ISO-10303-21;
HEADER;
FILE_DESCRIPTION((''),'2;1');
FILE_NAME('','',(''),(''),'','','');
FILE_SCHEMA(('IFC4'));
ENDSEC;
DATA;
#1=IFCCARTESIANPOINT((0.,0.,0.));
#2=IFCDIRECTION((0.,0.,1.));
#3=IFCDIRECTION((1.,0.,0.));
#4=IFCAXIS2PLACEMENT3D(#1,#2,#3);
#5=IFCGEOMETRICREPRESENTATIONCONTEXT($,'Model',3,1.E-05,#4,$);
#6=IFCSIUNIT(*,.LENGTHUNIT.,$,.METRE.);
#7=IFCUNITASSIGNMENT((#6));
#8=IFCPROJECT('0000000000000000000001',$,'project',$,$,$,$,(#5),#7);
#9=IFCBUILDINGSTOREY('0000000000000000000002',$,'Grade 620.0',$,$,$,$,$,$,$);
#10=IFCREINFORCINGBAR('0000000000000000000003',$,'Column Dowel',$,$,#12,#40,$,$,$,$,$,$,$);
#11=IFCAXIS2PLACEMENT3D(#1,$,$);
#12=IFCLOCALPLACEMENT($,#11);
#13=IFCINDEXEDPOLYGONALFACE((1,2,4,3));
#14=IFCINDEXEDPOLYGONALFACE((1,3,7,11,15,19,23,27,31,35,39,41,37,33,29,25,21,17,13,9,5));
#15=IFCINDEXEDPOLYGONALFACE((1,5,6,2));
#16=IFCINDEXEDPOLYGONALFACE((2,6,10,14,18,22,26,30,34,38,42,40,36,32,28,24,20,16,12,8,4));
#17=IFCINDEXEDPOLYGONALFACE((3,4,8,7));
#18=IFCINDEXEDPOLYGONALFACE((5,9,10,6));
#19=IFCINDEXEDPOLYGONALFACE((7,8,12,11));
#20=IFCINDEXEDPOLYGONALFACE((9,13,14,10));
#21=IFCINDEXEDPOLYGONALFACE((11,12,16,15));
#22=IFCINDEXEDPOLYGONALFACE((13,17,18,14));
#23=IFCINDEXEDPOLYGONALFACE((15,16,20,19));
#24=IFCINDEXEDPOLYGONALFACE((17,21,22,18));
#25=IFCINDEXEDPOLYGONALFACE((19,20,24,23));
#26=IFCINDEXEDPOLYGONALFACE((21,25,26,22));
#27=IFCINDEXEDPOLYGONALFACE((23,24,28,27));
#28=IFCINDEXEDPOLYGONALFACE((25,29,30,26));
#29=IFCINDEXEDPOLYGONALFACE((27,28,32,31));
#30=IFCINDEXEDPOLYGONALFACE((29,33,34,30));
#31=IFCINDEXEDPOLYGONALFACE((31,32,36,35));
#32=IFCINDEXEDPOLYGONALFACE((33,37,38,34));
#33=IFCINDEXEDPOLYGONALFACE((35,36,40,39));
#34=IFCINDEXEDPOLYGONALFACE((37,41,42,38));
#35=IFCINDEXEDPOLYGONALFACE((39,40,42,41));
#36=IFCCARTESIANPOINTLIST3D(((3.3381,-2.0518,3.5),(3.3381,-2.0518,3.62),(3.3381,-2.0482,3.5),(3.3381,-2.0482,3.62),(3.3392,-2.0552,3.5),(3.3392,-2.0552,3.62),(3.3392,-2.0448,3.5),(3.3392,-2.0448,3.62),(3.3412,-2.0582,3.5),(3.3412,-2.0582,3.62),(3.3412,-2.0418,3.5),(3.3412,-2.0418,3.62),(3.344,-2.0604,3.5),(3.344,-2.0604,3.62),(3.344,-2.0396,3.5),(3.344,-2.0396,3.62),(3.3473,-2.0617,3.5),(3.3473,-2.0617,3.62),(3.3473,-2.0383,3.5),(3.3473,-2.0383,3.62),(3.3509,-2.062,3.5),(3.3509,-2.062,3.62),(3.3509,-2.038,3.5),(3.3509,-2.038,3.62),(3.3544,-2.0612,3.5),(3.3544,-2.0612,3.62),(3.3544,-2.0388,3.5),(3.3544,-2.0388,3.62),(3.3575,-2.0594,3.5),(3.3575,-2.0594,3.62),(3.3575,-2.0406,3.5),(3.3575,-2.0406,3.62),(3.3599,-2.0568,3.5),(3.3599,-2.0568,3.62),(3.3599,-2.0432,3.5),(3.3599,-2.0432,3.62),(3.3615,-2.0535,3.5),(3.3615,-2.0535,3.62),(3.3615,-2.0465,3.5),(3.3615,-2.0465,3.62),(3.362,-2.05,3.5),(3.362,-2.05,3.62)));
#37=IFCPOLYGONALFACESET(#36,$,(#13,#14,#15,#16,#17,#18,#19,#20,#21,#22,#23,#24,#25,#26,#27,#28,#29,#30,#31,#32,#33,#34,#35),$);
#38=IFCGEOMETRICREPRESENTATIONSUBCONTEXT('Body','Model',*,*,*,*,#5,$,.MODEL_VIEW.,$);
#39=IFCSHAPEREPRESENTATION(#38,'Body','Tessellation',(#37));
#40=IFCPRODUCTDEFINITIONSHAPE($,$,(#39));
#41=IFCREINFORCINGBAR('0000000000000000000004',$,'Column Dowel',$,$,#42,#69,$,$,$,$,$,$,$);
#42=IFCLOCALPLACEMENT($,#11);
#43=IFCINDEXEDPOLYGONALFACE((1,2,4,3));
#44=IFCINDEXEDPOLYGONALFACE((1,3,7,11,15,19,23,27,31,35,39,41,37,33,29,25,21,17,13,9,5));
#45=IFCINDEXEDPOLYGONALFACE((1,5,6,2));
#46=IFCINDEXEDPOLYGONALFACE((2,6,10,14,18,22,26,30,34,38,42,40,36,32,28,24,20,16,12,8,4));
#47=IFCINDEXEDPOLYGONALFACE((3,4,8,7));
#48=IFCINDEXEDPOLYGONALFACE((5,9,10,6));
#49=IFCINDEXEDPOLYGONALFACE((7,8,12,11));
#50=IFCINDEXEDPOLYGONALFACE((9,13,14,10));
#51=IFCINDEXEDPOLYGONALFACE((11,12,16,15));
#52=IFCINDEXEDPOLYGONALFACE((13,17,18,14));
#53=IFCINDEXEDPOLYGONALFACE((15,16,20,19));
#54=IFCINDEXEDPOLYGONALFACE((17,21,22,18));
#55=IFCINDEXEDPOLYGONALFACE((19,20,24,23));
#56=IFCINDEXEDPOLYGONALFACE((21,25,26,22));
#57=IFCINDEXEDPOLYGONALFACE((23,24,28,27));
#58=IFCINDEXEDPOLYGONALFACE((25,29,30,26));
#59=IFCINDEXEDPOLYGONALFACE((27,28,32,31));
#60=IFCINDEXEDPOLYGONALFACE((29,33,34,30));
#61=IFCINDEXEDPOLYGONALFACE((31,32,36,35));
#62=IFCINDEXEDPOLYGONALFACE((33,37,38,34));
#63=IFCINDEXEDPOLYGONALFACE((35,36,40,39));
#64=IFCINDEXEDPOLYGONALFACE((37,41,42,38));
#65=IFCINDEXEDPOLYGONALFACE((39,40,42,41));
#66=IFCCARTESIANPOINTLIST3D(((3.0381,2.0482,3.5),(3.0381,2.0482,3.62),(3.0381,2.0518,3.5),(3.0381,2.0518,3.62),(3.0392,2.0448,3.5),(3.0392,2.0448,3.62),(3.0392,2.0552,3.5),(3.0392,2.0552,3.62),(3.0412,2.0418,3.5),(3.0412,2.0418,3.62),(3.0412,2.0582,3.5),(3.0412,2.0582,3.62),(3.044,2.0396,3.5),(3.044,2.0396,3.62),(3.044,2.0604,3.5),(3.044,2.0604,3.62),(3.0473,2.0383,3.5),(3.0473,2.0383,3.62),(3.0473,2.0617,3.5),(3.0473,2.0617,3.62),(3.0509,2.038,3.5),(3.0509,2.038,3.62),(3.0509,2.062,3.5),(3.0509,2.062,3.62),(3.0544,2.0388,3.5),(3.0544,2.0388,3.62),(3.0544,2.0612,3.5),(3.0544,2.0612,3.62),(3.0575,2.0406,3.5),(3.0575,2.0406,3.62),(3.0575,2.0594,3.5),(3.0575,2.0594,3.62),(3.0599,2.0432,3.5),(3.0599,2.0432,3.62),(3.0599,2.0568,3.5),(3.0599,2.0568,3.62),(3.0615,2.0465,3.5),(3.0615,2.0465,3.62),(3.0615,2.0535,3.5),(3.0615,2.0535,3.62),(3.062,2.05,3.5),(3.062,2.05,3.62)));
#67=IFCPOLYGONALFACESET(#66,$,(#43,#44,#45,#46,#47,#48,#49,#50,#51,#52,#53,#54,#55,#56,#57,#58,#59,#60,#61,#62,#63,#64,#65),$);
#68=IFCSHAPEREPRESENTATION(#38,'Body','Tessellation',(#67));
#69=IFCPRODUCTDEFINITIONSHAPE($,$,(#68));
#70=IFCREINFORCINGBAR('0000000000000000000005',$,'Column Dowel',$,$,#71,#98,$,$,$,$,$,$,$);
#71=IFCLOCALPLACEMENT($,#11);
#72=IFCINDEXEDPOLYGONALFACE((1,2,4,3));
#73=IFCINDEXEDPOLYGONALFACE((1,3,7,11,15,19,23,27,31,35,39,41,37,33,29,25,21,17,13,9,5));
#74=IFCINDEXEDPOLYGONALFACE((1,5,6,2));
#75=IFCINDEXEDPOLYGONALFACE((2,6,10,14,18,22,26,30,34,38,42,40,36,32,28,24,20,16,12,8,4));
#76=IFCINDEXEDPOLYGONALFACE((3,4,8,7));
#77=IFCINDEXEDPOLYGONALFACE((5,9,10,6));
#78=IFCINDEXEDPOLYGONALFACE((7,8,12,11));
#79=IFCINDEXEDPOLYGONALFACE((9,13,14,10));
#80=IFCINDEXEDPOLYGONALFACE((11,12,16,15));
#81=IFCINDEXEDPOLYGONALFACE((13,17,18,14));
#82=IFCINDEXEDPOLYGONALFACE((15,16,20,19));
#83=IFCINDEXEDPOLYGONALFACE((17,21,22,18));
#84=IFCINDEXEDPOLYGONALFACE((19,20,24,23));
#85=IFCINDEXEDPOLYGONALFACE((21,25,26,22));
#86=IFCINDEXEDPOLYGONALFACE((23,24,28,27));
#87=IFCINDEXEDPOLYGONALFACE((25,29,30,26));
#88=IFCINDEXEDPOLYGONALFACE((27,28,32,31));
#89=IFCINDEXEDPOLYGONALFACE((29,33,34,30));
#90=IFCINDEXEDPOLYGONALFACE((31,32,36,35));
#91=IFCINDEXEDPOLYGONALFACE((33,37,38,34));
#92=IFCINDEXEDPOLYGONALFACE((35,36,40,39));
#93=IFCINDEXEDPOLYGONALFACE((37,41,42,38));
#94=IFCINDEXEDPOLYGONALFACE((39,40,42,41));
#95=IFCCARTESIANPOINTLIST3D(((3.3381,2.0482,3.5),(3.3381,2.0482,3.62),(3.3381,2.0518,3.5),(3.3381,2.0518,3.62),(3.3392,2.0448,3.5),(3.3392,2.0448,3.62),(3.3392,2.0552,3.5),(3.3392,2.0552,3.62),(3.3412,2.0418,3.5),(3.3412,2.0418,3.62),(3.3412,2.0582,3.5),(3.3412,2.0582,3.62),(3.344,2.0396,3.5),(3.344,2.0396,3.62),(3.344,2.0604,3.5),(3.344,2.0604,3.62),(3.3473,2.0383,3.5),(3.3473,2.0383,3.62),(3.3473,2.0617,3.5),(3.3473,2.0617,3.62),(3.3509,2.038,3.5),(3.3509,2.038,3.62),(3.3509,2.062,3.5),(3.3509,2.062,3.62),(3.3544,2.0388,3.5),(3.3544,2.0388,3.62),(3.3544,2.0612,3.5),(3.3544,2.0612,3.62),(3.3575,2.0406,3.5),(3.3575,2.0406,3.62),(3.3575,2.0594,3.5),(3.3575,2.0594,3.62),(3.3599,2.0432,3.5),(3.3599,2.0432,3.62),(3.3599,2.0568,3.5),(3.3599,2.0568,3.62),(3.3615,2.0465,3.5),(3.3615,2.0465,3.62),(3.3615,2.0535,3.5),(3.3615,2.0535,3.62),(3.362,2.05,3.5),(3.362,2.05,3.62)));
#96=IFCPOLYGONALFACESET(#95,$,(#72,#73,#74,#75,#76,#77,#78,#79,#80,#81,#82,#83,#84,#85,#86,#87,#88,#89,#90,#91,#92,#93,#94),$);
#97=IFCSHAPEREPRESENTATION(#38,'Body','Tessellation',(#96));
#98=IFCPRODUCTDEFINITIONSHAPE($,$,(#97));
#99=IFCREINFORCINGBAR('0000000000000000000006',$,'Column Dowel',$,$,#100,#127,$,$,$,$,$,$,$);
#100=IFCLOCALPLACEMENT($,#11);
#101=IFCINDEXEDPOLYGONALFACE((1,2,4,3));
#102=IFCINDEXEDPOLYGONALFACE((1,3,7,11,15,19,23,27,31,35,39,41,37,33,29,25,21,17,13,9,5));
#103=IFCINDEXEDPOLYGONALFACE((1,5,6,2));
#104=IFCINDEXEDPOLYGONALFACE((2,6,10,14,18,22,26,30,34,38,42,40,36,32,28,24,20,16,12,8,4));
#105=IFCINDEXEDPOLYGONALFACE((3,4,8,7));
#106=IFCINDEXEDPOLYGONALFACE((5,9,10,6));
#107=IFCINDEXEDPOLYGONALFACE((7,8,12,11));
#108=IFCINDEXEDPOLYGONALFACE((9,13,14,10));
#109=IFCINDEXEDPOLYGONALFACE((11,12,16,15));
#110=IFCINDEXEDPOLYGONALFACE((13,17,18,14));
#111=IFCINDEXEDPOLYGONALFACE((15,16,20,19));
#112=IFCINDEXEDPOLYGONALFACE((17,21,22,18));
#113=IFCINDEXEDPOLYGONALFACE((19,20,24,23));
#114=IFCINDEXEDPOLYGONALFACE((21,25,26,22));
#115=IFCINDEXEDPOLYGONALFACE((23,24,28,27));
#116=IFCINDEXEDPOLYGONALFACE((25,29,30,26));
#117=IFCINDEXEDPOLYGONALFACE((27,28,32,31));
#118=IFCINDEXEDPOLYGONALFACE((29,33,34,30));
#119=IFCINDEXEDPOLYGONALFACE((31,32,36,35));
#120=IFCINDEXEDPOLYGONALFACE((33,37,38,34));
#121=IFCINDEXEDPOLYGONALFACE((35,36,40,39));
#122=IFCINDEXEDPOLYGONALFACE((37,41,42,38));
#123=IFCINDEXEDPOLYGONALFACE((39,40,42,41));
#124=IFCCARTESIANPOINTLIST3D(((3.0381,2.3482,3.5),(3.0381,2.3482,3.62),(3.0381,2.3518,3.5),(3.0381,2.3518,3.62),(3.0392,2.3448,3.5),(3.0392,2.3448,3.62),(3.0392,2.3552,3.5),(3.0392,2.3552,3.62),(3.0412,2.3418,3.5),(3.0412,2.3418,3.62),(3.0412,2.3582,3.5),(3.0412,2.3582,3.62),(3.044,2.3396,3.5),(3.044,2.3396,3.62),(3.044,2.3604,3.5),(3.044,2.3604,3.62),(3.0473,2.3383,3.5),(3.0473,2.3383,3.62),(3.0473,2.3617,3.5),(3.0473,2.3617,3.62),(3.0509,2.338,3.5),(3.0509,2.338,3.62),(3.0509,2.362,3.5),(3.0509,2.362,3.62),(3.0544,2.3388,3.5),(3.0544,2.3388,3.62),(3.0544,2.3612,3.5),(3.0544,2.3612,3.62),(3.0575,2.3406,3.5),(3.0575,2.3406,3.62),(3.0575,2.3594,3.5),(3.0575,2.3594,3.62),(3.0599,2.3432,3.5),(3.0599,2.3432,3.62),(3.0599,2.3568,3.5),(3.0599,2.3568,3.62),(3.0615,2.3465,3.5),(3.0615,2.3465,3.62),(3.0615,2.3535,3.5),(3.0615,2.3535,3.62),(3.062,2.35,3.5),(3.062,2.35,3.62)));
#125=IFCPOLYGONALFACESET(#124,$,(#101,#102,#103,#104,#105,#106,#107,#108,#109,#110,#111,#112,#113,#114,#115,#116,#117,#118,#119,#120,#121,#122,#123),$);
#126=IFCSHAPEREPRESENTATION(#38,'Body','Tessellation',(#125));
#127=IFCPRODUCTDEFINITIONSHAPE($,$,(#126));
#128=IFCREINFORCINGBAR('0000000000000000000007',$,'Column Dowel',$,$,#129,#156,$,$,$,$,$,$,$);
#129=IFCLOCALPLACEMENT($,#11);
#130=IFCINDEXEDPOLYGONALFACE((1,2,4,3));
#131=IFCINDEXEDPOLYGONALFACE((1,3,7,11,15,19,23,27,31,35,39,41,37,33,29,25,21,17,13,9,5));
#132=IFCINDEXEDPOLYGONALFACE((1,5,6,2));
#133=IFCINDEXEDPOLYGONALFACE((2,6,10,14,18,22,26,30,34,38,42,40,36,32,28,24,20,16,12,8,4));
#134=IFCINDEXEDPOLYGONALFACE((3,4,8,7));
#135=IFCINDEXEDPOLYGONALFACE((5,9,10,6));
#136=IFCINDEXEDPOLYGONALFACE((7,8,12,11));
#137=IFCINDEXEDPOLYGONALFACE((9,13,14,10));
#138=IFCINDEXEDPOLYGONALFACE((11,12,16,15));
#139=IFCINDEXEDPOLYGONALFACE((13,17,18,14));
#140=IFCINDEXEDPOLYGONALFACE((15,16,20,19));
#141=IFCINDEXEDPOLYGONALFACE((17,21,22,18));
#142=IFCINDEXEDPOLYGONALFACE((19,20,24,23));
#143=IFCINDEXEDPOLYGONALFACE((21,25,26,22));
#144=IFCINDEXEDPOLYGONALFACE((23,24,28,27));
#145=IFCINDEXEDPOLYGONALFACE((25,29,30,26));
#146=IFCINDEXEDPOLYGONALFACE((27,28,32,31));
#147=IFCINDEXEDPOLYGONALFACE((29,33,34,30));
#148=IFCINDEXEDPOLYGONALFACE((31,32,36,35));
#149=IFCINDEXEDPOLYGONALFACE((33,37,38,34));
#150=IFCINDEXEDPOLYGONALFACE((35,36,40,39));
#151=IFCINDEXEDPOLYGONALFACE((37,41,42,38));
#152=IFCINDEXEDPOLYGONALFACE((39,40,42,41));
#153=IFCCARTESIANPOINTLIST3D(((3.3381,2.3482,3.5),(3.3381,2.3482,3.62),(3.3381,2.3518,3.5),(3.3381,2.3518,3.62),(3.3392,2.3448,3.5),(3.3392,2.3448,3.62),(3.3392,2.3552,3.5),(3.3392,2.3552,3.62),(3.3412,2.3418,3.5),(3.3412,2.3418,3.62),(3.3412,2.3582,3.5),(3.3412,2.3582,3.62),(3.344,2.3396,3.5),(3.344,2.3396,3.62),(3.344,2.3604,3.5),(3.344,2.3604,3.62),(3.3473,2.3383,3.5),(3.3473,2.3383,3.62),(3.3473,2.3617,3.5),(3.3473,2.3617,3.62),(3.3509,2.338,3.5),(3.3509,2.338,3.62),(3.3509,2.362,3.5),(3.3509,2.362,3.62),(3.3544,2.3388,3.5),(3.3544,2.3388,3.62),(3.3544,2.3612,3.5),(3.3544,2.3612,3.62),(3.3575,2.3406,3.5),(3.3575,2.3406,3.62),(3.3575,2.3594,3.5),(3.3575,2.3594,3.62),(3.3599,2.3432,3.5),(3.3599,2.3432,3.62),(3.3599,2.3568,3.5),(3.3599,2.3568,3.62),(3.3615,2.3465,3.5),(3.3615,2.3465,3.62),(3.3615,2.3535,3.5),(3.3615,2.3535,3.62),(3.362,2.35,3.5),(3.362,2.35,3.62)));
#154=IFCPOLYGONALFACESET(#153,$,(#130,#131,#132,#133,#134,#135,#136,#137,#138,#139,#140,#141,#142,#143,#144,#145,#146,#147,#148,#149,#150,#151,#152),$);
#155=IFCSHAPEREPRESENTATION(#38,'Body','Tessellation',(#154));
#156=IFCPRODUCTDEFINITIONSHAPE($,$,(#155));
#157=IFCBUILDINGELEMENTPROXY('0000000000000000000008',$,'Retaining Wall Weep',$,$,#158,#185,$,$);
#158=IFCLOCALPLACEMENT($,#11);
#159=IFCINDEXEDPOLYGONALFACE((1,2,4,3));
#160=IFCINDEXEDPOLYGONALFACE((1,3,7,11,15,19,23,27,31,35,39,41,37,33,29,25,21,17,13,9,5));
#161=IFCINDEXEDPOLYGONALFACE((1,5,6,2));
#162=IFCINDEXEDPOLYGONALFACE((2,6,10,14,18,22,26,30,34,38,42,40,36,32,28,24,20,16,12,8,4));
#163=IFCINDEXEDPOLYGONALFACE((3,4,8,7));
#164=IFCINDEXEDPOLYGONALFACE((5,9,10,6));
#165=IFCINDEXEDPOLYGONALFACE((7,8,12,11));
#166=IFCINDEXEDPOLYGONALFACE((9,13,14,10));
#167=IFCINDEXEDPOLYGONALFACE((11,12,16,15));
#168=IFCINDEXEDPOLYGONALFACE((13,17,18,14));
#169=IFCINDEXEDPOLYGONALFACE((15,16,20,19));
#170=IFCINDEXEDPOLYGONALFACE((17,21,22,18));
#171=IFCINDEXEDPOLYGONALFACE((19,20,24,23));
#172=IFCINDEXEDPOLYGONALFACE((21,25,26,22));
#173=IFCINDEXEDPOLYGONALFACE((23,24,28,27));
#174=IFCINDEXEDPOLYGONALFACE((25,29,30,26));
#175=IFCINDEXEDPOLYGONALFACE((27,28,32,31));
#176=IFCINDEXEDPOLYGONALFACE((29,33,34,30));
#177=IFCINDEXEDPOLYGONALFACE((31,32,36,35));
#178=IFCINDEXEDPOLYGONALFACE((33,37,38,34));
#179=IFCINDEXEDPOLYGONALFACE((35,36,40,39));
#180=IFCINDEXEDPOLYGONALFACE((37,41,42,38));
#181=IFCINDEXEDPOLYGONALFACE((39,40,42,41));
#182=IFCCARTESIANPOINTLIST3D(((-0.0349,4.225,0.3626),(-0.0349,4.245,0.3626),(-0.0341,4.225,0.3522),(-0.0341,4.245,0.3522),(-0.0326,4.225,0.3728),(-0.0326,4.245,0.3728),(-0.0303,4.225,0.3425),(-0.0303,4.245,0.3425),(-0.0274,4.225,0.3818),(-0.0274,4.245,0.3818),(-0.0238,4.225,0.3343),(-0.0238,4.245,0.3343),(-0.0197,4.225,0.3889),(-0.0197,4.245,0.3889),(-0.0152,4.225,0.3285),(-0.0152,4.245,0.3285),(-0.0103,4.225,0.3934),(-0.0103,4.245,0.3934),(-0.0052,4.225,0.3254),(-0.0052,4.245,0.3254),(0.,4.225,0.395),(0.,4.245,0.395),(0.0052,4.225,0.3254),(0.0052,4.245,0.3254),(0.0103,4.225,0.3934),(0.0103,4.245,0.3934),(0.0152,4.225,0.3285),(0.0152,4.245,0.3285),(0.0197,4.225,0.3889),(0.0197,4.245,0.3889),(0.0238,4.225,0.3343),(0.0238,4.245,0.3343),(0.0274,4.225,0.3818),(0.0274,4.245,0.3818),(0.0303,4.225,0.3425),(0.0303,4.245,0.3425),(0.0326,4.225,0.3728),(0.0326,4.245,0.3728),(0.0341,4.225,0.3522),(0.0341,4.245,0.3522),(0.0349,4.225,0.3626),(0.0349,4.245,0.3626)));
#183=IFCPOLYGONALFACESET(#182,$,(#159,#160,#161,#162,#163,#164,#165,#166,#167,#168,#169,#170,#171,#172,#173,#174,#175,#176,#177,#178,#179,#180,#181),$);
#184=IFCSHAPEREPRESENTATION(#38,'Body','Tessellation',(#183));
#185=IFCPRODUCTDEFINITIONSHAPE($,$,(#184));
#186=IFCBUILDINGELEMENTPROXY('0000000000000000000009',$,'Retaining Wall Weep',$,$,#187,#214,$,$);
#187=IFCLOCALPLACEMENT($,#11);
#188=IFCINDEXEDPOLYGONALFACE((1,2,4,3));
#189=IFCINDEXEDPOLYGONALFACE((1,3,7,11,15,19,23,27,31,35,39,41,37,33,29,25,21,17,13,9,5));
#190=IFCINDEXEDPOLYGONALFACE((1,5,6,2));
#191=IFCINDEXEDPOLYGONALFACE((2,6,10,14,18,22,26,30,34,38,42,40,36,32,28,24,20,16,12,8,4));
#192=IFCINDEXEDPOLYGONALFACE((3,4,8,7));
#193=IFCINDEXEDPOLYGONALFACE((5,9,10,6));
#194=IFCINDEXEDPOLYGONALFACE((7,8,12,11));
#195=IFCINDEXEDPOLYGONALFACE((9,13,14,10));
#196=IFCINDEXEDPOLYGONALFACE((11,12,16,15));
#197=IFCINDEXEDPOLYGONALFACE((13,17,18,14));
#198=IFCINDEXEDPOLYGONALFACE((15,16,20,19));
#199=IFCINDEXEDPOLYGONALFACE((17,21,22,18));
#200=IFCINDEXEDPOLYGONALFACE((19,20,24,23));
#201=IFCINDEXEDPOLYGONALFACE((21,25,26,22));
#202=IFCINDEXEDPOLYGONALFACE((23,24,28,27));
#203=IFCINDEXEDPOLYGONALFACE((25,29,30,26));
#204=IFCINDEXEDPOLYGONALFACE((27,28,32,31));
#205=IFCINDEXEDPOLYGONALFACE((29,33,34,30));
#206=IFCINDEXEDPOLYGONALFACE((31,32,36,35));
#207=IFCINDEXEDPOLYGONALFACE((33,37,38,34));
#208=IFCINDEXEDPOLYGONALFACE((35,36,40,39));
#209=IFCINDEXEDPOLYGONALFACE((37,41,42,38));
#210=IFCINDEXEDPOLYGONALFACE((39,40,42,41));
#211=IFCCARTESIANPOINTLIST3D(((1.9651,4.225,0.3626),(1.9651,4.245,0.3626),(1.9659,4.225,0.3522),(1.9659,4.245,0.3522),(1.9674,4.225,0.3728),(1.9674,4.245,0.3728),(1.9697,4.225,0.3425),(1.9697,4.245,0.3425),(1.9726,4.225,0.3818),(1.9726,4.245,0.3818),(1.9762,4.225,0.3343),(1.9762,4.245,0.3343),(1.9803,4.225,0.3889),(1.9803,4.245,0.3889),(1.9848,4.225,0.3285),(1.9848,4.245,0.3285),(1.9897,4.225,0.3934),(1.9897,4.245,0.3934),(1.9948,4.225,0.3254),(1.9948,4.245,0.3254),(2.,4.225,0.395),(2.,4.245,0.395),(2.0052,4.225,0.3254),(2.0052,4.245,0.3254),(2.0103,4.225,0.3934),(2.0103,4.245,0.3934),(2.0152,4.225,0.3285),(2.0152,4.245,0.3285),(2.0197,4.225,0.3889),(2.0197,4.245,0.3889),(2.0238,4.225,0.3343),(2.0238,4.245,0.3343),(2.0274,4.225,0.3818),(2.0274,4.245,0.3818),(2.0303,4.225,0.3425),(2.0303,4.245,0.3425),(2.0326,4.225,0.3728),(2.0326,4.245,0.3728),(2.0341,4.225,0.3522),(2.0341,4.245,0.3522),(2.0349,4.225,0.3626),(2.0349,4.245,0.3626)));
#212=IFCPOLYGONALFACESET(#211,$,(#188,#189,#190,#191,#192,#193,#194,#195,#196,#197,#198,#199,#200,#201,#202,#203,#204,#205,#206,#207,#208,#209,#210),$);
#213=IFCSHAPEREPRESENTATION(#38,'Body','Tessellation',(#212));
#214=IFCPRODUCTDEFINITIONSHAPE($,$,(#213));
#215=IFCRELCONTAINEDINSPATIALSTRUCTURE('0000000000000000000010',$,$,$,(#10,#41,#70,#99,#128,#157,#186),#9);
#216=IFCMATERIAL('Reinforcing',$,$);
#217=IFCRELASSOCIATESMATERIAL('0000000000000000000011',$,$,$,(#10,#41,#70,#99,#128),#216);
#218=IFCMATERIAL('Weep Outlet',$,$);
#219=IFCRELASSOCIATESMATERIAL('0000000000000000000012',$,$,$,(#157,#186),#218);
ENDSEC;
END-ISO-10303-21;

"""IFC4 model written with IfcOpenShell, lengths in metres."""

from ifc_helpers import new_model, si_unit, frame, origin_with_axes, place, context, subcontext, project, spatial, circle, extrude, material, element, save


model = new_model("IFC4")

# Units and contexts
model_context = context("Model", 3, precision=1e-05, world=origin_with_axes())
body_context = subcontext(model_context, "Body", "Model", "MODEL_VIEW")
ifc_project = project(units=[si_unit("LENGTHUNIT", "METRE")], contexts=[model_context])

# Storey
storey = spatial("IfcBuildingStorey", Name="Grade 620.0")

# Reinforcing bars
ifc_material_1 = material(Name="Reinforcing")
for number, where, z_axis, x_axis, name in (
    (1, (3.35, -2.05, 3.5), (0.0, 0.0, 1.0), (1.0, 0.0, 0.0), "Column Dowel"),
    (2, (3.05, 2.05, 3.5), (0.0, 0.0, 1.0), (1.0, 0.0, 0.0), "Column Dowel"),
    (3, (3.35, 2.05, 3.5), (0.0, 0.0, 1.0), (1.0, 0.0, 0.0), "Column Dowel"),
    (4, (3.05, 2.35, 3.5), (0.0, 0.0, 1.0), (1.0, 0.0, 0.0), "Column Dowel"),
    (5, (3.35, 2.35, 3.5), (0.0, 0.0, 1.0), (1.0, 0.0, 0.0), "Column Dowel"),
):
    element("IfcReinforcingBar", number, at=place(None, frame(where, z_axis=z_axis, x_axis=x_axis)), inside=storey, material=ifc_material_1, Name=name, context=body_context, shape_type="SweptSolid", body=[
        extrude(circle(Radius=0.012), origin_with_axes(), (0.0, 0.0, 1.0), 0.12),
    ])

# Building element proxies
ifc_material_2 = material(Name="Weep Outlet")
for number, where, z_axis, x_axis, name in (
    (6, (0.0, 4.225, 0.36), (0.0, 1.0, 0.0), (0.0, 0.0, 1.0), "Retaining Wall Weep"),
    (7, (2.0, 4.225, 0.36), (0.0, 1.0, 0.0), (0.0, 0.0, 1.0), "Retaining Wall Weep"),
):
    element("IfcBuildingElementProxy", number, at=place(None, frame(where, z_axis=z_axis, x_axis=x_axis)), inside=storey, material=ifc_material_2, Name=name, context=body_context, shape_type="SweptSolid", body=[
        extrude(circle(Radius=0.035), origin_with_axes(), (0.0, 0.0, 1.0), 0.02),
    ])

save(model, "model.ifc")
